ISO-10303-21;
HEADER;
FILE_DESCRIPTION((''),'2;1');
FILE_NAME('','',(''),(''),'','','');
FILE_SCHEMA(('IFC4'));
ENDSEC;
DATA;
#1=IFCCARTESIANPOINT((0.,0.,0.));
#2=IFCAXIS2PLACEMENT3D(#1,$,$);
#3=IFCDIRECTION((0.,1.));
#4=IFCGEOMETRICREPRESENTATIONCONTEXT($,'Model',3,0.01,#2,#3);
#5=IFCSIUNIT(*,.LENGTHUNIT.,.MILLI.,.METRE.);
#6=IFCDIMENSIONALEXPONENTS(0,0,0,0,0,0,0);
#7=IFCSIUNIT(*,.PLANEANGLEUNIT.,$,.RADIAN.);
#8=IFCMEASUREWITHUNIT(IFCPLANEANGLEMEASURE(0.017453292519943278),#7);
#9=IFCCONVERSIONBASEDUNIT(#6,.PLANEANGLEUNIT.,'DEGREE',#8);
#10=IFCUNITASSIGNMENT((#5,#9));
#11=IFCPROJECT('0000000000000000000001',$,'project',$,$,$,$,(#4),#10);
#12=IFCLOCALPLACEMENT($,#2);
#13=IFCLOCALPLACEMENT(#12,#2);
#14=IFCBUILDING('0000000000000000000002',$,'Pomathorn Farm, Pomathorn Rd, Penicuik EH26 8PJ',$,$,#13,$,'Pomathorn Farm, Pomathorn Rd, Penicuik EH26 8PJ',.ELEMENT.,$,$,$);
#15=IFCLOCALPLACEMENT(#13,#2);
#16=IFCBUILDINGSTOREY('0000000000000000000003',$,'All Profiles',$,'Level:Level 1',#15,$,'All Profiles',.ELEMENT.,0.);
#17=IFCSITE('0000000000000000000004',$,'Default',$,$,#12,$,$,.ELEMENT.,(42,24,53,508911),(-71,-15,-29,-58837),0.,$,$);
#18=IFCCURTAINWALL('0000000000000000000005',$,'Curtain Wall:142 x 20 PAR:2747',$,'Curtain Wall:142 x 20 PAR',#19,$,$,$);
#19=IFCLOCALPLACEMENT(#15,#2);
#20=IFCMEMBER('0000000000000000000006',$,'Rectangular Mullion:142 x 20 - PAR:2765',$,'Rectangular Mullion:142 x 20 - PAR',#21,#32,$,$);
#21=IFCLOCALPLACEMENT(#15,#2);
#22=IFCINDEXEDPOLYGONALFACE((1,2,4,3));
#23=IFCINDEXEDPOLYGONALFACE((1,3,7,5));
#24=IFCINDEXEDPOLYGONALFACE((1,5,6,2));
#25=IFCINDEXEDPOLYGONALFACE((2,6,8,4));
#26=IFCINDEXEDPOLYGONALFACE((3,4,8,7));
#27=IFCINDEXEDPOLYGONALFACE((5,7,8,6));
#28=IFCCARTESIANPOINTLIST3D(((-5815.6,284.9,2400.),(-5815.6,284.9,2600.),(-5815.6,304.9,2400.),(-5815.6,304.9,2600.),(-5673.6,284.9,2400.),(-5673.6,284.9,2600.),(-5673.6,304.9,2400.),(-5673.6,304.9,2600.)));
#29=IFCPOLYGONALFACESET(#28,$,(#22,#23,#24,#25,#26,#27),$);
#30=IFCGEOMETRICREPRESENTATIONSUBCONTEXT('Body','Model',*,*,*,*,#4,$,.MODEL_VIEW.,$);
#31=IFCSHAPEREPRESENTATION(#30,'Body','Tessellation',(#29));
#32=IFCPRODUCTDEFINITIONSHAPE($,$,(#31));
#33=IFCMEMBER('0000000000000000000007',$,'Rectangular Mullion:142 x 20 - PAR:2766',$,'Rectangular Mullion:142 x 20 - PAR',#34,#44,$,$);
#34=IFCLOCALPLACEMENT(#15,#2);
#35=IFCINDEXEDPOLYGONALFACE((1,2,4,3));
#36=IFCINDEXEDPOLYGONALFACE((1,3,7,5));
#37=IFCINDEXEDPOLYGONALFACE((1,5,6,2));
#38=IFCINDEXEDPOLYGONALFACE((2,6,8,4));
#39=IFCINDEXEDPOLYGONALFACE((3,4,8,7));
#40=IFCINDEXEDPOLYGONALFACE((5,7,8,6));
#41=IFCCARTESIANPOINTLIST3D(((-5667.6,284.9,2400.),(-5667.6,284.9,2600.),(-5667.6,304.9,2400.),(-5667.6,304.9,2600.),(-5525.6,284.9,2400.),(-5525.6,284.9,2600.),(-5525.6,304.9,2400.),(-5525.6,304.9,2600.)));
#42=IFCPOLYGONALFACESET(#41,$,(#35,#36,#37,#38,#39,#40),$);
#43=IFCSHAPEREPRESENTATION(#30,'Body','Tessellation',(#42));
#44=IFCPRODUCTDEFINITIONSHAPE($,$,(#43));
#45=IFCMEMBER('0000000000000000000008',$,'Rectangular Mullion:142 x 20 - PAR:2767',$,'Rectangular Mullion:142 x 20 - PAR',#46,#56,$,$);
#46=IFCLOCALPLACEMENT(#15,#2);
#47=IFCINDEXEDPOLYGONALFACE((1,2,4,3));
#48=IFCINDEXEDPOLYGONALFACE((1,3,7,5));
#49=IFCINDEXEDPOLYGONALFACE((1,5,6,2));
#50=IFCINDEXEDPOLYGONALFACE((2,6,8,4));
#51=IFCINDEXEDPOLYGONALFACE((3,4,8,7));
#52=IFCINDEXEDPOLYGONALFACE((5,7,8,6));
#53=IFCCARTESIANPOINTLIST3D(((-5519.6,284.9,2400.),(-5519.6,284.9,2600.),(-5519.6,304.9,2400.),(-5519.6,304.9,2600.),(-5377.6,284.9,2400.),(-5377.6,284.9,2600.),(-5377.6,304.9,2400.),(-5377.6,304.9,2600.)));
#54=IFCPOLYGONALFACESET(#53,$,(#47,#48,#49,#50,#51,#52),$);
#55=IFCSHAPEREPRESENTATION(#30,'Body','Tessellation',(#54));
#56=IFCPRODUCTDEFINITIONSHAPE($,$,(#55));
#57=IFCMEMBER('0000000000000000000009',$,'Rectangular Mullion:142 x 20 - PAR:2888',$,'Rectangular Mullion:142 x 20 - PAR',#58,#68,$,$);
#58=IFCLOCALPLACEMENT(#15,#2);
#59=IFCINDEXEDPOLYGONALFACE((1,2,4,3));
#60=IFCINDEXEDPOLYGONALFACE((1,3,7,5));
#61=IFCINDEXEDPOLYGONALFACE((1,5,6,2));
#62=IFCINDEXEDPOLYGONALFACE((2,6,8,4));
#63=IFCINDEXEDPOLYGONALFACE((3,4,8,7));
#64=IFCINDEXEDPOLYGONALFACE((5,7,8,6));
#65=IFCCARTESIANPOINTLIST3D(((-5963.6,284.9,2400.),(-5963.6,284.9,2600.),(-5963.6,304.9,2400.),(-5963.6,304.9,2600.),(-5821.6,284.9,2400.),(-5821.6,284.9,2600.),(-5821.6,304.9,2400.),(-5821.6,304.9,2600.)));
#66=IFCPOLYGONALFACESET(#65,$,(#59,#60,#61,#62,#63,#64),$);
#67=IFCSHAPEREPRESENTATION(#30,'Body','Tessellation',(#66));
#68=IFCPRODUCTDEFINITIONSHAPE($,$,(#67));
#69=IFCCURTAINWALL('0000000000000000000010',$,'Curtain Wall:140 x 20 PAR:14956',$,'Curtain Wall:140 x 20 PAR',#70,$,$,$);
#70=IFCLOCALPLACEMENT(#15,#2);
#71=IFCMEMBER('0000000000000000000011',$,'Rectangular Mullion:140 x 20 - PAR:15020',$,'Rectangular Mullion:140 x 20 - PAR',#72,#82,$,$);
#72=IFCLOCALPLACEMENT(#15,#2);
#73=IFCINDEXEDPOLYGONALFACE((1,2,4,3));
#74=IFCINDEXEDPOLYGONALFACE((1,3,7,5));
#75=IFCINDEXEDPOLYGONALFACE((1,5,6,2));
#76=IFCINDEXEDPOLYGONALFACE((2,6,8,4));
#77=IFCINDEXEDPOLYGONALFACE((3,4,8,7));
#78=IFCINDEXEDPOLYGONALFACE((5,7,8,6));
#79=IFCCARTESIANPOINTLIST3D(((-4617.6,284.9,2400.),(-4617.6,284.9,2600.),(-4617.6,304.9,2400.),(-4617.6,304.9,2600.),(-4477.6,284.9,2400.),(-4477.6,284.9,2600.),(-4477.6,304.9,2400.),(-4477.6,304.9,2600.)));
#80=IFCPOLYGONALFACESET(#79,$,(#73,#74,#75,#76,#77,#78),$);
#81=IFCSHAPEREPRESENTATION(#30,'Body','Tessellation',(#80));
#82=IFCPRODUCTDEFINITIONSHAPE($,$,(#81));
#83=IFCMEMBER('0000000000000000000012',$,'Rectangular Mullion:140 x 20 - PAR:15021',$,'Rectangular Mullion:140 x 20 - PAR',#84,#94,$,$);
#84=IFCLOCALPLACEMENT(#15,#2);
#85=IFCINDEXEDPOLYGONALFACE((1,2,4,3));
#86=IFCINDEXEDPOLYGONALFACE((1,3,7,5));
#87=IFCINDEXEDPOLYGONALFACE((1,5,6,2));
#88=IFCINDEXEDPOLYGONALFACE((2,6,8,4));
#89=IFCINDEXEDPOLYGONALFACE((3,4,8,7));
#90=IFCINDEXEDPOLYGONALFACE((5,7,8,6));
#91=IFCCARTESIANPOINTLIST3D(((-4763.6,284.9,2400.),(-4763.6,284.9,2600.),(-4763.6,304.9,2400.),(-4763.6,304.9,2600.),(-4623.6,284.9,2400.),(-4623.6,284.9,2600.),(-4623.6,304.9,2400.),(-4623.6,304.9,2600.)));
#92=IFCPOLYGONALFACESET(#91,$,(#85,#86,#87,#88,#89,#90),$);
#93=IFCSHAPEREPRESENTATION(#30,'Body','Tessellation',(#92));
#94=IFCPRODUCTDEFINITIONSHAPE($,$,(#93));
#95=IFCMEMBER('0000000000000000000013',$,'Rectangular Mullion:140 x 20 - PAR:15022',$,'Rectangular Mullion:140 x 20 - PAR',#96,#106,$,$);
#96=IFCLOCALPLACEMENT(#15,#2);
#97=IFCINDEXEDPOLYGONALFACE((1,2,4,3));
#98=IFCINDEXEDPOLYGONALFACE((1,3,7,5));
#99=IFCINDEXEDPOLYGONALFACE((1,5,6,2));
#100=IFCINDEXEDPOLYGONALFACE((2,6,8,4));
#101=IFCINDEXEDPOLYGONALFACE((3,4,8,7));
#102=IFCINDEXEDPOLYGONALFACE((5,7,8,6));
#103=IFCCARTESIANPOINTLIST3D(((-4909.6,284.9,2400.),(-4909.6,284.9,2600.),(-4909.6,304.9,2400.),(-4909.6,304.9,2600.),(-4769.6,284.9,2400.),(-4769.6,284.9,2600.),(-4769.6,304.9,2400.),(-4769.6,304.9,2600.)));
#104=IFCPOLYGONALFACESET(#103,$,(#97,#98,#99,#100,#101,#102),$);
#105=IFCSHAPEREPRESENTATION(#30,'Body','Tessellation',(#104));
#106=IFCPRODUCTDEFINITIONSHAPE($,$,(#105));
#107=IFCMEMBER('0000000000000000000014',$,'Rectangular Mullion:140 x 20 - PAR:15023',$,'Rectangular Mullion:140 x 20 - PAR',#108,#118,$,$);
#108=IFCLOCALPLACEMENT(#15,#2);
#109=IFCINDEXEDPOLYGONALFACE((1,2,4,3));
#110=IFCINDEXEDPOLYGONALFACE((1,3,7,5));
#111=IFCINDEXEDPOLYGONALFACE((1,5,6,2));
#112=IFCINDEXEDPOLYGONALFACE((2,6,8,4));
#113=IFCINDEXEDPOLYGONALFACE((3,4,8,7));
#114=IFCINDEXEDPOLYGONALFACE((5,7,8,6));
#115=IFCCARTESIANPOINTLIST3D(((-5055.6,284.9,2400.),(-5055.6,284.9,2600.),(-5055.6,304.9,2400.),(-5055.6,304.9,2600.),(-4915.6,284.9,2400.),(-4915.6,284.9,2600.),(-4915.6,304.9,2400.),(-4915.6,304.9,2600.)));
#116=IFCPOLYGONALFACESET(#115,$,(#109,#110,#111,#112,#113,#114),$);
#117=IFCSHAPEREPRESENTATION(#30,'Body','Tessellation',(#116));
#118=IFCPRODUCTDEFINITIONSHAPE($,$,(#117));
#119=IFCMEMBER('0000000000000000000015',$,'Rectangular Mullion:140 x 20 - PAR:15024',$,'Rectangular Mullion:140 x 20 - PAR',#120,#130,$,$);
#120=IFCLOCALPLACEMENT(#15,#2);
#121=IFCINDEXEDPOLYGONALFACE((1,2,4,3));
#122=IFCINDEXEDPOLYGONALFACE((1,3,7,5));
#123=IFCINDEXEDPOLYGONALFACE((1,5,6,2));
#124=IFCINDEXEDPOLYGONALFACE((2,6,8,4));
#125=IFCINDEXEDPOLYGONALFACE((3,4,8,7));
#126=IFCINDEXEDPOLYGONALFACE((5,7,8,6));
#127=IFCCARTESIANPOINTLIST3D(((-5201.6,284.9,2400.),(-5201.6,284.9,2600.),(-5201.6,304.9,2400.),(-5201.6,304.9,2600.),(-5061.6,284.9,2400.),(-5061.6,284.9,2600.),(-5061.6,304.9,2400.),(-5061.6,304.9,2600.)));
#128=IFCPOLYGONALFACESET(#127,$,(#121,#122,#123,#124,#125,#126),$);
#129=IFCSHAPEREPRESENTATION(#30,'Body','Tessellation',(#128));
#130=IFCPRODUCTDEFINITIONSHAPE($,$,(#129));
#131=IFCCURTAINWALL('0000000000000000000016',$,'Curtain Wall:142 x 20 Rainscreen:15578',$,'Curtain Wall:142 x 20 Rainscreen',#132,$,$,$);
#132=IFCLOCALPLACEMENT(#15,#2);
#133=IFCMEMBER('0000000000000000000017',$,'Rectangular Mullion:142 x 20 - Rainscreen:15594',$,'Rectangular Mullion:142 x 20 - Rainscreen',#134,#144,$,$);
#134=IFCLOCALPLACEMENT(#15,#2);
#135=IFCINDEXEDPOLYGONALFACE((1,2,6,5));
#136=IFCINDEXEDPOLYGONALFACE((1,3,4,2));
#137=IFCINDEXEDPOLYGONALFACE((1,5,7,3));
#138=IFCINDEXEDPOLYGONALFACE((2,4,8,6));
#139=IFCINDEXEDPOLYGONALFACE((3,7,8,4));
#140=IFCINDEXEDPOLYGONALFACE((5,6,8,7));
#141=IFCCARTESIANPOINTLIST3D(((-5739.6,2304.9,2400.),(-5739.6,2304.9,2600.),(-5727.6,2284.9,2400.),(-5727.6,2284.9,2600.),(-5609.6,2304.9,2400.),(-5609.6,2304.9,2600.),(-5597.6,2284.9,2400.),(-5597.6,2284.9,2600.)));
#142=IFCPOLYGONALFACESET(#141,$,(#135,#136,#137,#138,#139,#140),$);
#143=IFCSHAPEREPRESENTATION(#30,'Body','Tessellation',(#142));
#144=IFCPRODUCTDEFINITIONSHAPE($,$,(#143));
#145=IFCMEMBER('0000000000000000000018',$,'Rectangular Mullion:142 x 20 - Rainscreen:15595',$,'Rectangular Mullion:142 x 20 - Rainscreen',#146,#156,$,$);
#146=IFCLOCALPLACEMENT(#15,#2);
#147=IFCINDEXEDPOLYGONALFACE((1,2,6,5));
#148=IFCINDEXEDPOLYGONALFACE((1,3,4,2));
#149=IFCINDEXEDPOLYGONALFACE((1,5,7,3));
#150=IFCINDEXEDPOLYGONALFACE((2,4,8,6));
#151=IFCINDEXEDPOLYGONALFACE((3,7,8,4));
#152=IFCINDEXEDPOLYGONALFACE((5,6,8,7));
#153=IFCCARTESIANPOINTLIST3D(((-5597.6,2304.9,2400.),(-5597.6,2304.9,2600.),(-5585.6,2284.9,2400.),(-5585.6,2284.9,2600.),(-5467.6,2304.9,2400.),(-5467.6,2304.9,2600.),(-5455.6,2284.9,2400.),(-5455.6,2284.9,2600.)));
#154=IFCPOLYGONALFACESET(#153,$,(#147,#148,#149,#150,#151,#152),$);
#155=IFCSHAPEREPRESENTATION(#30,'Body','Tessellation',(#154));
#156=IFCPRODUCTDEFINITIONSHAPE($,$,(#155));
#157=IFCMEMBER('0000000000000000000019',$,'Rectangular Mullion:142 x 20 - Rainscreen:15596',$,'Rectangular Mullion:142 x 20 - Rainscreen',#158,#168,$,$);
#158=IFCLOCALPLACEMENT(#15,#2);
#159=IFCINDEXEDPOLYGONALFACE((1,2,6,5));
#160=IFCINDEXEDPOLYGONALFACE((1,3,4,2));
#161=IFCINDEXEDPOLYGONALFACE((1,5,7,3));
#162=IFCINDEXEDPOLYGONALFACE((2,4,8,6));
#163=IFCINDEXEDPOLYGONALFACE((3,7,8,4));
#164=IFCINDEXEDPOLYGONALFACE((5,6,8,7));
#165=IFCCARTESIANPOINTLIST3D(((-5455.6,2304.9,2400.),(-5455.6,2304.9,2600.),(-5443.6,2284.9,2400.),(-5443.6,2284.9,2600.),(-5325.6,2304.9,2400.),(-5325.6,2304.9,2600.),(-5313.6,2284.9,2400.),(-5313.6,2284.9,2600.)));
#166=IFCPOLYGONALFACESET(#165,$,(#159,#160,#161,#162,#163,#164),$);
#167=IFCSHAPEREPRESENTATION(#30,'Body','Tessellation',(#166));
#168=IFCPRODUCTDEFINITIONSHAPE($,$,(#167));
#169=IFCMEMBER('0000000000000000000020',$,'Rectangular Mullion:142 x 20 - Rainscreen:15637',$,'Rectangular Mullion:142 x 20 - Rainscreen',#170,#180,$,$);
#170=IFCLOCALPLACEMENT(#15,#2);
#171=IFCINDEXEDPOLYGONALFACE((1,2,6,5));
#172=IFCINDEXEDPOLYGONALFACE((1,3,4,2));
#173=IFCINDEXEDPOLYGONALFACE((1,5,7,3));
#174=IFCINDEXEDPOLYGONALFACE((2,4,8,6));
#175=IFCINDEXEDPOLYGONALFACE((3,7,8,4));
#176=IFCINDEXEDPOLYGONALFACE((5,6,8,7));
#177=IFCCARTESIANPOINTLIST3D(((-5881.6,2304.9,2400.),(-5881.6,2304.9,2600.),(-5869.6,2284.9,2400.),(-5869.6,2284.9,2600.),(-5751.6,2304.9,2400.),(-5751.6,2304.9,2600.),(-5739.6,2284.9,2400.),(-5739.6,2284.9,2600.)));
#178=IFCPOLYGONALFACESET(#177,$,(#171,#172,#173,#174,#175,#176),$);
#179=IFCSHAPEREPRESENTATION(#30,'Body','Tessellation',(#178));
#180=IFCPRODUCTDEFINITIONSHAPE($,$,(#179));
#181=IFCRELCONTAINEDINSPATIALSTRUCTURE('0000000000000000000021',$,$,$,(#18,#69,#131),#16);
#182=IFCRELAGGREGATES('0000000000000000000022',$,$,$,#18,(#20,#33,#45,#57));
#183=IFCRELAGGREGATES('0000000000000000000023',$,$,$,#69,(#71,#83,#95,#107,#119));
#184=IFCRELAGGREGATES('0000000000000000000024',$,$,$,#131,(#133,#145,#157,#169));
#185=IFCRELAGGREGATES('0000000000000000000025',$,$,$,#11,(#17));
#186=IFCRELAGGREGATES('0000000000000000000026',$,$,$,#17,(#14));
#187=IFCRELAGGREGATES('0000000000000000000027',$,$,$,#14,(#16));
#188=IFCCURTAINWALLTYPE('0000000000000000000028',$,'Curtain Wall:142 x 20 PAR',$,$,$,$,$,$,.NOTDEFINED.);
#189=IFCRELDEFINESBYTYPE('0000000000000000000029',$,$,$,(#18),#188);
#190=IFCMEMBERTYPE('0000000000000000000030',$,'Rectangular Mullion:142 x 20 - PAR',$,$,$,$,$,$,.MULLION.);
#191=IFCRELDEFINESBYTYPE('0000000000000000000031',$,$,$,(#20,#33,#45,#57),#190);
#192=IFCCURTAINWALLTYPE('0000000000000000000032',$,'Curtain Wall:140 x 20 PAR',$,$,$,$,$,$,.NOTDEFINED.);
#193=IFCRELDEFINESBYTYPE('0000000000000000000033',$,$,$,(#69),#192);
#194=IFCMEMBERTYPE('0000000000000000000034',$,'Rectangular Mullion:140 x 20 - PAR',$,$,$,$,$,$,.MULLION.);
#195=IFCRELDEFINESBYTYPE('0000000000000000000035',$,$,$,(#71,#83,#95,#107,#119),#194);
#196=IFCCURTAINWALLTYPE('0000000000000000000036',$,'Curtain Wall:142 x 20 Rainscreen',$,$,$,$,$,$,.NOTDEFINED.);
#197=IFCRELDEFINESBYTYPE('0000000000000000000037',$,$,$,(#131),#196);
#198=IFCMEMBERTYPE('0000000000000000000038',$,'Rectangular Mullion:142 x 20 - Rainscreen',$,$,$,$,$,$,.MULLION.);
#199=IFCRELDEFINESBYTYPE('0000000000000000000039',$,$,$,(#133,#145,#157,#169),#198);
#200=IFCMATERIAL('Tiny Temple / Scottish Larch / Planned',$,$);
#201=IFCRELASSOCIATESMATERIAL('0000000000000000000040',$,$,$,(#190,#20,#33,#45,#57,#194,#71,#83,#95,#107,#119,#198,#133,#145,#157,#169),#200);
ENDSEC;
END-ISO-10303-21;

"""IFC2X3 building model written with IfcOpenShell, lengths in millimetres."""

from ifc_helpers import new_model, entity, si_unit, converted_unit, direction, frame, frame_2d, origin, place, context, subcontext, project, spatial, polyline, rectangle, outline, extrude, source, transform, mapped, material, type_object, type_shapes, element, aggregate, save


model = new_model("IFC2X3")

# Units and contexts
model_context = context("Model", 3, precision=0.01, world=origin(), true_north=direction((0.0, 1.0)))
body_context = subcontext(model_context, "Body", "Model", "MODEL_VIEW")
ifc_project = project(units=[si_unit("LENGTHUNIT", "METRE", prefix="MILLI"), converted_unit("PLANEANGLEUNIT", "DEGREE", entity("IfcPlaneAngleMeasure", 0.017453292519943278), si_unit("PLANEANGLEUNIT", "RADIAN"), dimensions=[0, 0, 0, 0, 0, 0, 0])], contexts=[model_context])

# Site, building, storey
site_placement = place(None, origin())
site = spatial("IfcSite", under=ifc_project, at=site_placement, Name="Default", CompositionType="ELEMENT", RefLatitude=(42, 24, 53, 508911), RefLongitude=(-71, -15, -29, -58837), RefElevation=0.0)
building_placement = place(site_placement, origin())
building = spatial("IfcBuilding", under=site, at=building_placement, Name="Pomathorn Farm, Pomathorn Rd, Penicuik EH26 8PJ", LongName="Pomathorn Farm, Pomathorn Rd, Penicuik EH26 8PJ", CompositionType="ELEMENT")
storey_placement = place(building_placement, origin())
storey = spatial("IfcBuildingStorey", under=building, at=storey_placement, Name="All Profiles", ObjectType="Level:Level 1", LongName="All Profiles", CompositionType="ELEMENT", Elevation=0.0)

# Curtain walls, members
curtain_wall_type_1 = type_object("IfcCurtainWallType", Name="Curtain Wall:142 x 20 PAR", PredefinedType="NOTDEFINED")
curtain_wall_1_placement = place(storey_placement, origin())
curtain_wall_1 = element("IfcCurtainWall", 1, at=curtain_wall_1_placement, inside=storey, type_object=curtain_wall_type_1, Name="Curtain Wall:142 x 20 PAR:2747", ObjectType="Curtain Wall:142 x 20 PAR")
ifc_material = material(Name="Tiny Temple / Scottish Larch / Planned")
member_type_1 = type_object("IfcMemberType", Name="Rectangular Mullion:142 x 20 - PAR", PredefinedType="MULLION", material=ifc_material)
shared_shape_1 = source(origin(), body_context, "Body", "SweptSolid", [
    extrude(rectangle(XDim=20.0, YDim=142.0, at=frame_2d((0.0, 0.0), x_axis=(1.0, 0.0))), frame((-71.0, -10.0, -200.0), z_axis=(0.0, 0.0, 1.0), x_axis=(0.0, 1.0, 0.0)), (0.0, 0.0, 1.0), 200.0),
])
type_shapes(member_type_1, [shared_shape_1])
member_1_placement = place(curtain_wall_1_placement, frame((-5673.6, 284.9, 2400.0), z_axis=(0.0, 0.0, -1.0), x_axis=(1.0, 0.0, 0.0)))
member_1 = element("IfcMember", 2, at=member_1_placement, type_object=member_type_1, material=ifc_material, Name="Rectangular Mullion:142 x 20 - PAR:2765", ObjectType="Rectangular Mullion:142 x 20 - PAR", context=body_context, shape_type="MappedRepresentation", body=[
    mapped(shared_shape_1, transform((0.0, 0.0, 0.0), scale=1.0)),
])
member_2_placement = place(curtain_wall_1_placement, frame((-5525.6, 284.9, 2400.0), z_axis=(0.0, 0.0, -1.0), x_axis=(1.0, 0.0, 0.0)))
member_2 = element("IfcMember", 3, at=member_2_placement, type_object=member_type_1, material=ifc_material, Name="Rectangular Mullion:142 x 20 - PAR:2766", ObjectType="Rectangular Mullion:142 x 20 - PAR", context=body_context, shape_type="MappedRepresentation", body=[
    mapped(shared_shape_1, transform((0.0, 0.0, 0.0), scale=1.0)),
])
member_3_placement = place(curtain_wall_1_placement, frame((-5377.6, 284.9, 2400.0), z_axis=(0.0, 0.0, -1.0), x_axis=(1.0, 0.0, 0.0)))
member_3 = element("IfcMember", 4, at=member_3_placement, type_object=member_type_1, material=ifc_material, Name="Rectangular Mullion:142 x 20 - PAR:2767", ObjectType="Rectangular Mullion:142 x 20 - PAR", context=body_context, shape_type="MappedRepresentation", body=[
    mapped(shared_shape_1, transform((0.0, 0.0, 0.0), scale=1.0)),
])
member_4_placement = place(curtain_wall_1_placement, frame((-5821.6, 284.9, 2400.0), z_axis=(0.0, 0.0, -1.0), x_axis=(1.0, 0.0, 0.0)))
member_4 = element("IfcMember", 5, at=member_4_placement, type_object=member_type_1, material=ifc_material, Name="Rectangular Mullion:142 x 20 - PAR:2888", ObjectType="Rectangular Mullion:142 x 20 - PAR", context=body_context, shape_type="MappedRepresentation", body=[
    mapped(shared_shape_1, transform((0.0, 0.0, 0.0), scale=1.0)),
])
aggregate(curtain_wall_1, [member_1, member_2, member_3, member_4])
curtain_wall_type_2 = type_object("IfcCurtainWallType", Name="Curtain Wall:140 x 20 PAR", PredefinedType="NOTDEFINED")
curtain_wall_2_placement = place(storey_placement, origin())
curtain_wall_2 = element("IfcCurtainWall", 6, at=curtain_wall_2_placement, inside=storey, type_object=curtain_wall_type_2, Name="Curtain Wall:140 x 20 PAR:14956", ObjectType="Curtain Wall:140 x 20 PAR")
member_type_2 = type_object("IfcMemberType", Name="Rectangular Mullion:140 x 20 - PAR", PredefinedType="MULLION", material=ifc_material)
shared_shape_2 = source(origin(), body_context, "Body", "SweptSolid", [
    extrude(rectangle(XDim=20.0, YDim=140.0, at=frame_2d((0.0, 0.0), x_axis=(1.0, 0.0))), frame((-70.0, -10.0, -200.0), z_axis=(0.0, 0.0, 1.0), x_axis=(0.0, 1.0, 0.0)), (0.0, 0.0, 1.0), 200.0),
])
type_shapes(member_type_2, [shared_shape_2])
member_5_placement = place(curtain_wall_2_placement, frame((-4477.6, 284.9, 2400.0), z_axis=(0.0, 0.0, -1.0), x_axis=(1.0, 0.0, 0.0)))
member_5 = element("IfcMember", 7, at=member_5_placement, type_object=member_type_2, material=ifc_material, Name="Rectangular Mullion:140 x 20 - PAR:15020", ObjectType="Rectangular Mullion:140 x 20 - PAR", context=body_context, shape_type="MappedRepresentation", body=[
    mapped(shared_shape_2, transform((0.0, 0.0, 0.0), scale=1.0)),
])
member_6_placement = place(curtain_wall_2_placement, frame((-4623.6, 284.9, 2400.0), z_axis=(0.0, 0.0, -1.0), x_axis=(1.0, 0.0, 0.0)))
member_6 = element("IfcMember", 8, at=member_6_placement, type_object=member_type_2, material=ifc_material, Name="Rectangular Mullion:140 x 20 - PAR:15021", ObjectType="Rectangular Mullion:140 x 20 - PAR", context=body_context, shape_type="MappedRepresentation", body=[
    mapped(shared_shape_2, transform((0.0, 0.0, 0.0), scale=1.0)),
])
member_7_placement = place(curtain_wall_2_placement, frame((-4769.6, 284.9, 2400.0), z_axis=(0.0, 0.0, -1.0), x_axis=(1.0, 0.0, 0.0)))
member_7 = element("IfcMember", 9, at=member_7_placement, type_object=member_type_2, material=ifc_material, Name="Rectangular Mullion:140 x 20 - PAR:15022", ObjectType="Rectangular Mullion:140 x 20 - PAR", context=body_context, shape_type="MappedRepresentation", body=[
    mapped(shared_shape_2, transform((0.0, 0.0, 0.0), scale=1.0)),
])
member_8_placement = place(curtain_wall_2_placement, frame((-4915.6, 284.9, 2400.0), z_axis=(0.0, 0.0, -1.0), x_axis=(1.0, 0.0, 0.0)))
member_8 = element("IfcMember", 10, at=member_8_placement, type_object=member_type_2, material=ifc_material, Name="Rectangular Mullion:140 x 20 - PAR:15023", ObjectType="Rectangular Mullion:140 x 20 - PAR", context=body_context, shape_type="MappedRepresentation", body=[
    mapped(shared_shape_2, transform((0.0, 0.0, 0.0), scale=1.0)),
])
member_9_placement = place(curtain_wall_2_placement, frame((-5061.6, 284.9, 2400.0), z_axis=(0.0, 0.0, -1.0), x_axis=(1.0, 0.0, 0.0)))
member_9 = element("IfcMember", 11, at=member_9_placement, type_object=member_type_2, material=ifc_material, Name="Rectangular Mullion:140 x 20 - PAR:15024", ObjectType="Rectangular Mullion:140 x 20 - PAR", context=body_context, shape_type="MappedRepresentation", body=[
    mapped(shared_shape_2, transform((0.0, 0.0, 0.0), scale=1.0)),
])
aggregate(curtain_wall_2, [member_5, member_6, member_7, member_8, member_9])
curtain_wall_type_3 = type_object("IfcCurtainWallType", Name="Curtain Wall:142 x 20 Rainscreen", PredefinedType="NOTDEFINED")
curtain_wall_3_placement = place(storey_placement, origin())
curtain_wall_3 = element("IfcCurtainWall", 12, at=curtain_wall_3_placement, inside=storey, type_object=curtain_wall_type_3, Name="Curtain Wall:142 x 20 Rainscreen:15578", ObjectType="Curtain Wall:142 x 20 Rainscreen")
member_type_3 = type_object("IfcMemberType", Name="Rectangular Mullion:142 x 20 - Rainscreen", PredefinedType="MULLION", material=ifc_material)
shared_shape_3 = source(origin(), body_context, "Body", "SweptSolid", [
    extrude(outline(polyline([(21.8, -55.7), (45.1, -55.7), (-21.8, 55.7), (-45.1, 55.7), (21.8, -55.7)])), frame((-71.0, -10.0, -200.0), z_axis=(0.0, 0.0, 1.0), x_axis=(0.514496, 0.857493, 0.0)), (0.0, 0.0, 1.0), 200.0),
])
type_shapes(member_type_3, [shared_shape_3])
member_10_placement = place(curtain_wall_3_placement, frame((-5597.6, 2284.9, 2400.0), z_axis=(0.0, 0.0, -1.0), x_axis=(1.0, 0.0, 0.0)))
member_10 = element("IfcMember", 13, at=member_10_placement, type_object=member_type_3, material=ifc_material, Name="Rectangular Mullion:142 x 20 - Rainscreen:15594", ObjectType="Rectangular Mullion:142 x 20 - Rainscreen", context=body_context, shape_type="MappedRepresentation", body=[
    mapped(shared_shape_3, transform((0.0, 0.0, 0.0), scale=1.0)),
])
member_11_placement = place(curtain_wall_3_placement, frame((-5455.6, 2284.9, 2400.0), z_axis=(0.0, 0.0, -1.0), x_axis=(1.0, 0.0, 0.0)))
member_11 = element("IfcMember", 14, at=member_11_placement, type_object=member_type_3, material=ifc_material, Name="Rectangular Mullion:142 x 20 - Rainscreen:15595", ObjectType="Rectangular Mullion:142 x 20 - Rainscreen", context=body_context, shape_type="MappedRepresentation", body=[
    mapped(shared_shape_3, transform((0.0, 0.0, 0.0), scale=1.0)),
])
member_12_placement = place(curtain_wall_3_placement, frame((-5313.6, 2284.9, 2400.0), z_axis=(0.0, 0.0, -1.0), x_axis=(1.0, 0.0, 0.0)))
member_12 = element("IfcMember", 15, at=member_12_placement, type_object=member_type_3, material=ifc_material, Name="Rectangular Mullion:142 x 20 - Rainscreen:15596", ObjectType="Rectangular Mullion:142 x 20 - Rainscreen", context=body_context, shape_type="MappedRepresentation", body=[
    mapped(shared_shape_3, transform((0.0, 0.0, 0.0), scale=1.0)),
])
member_13_placement = place(curtain_wall_3_placement, frame((-5739.6, 2284.9, 2400.0), z_axis=(0.0, 0.0, -1.0), x_axis=(1.0, 0.0, 0.0)))
member_13 = element("IfcMember", 16, at=member_13_placement, type_object=member_type_3, material=ifc_material, Name="Rectangular Mullion:142 x 20 - Rainscreen:15637", ObjectType="Rectangular Mullion:142 x 20 - Rainscreen", context=body_context, shape_type="MappedRepresentation", body=[
    mapped(shared_shape_3, transform((0.0, 0.0, 0.0), scale=1.0)),
])
aggregate(curtain_wall_3, [member_10, member_11, member_12, member_13])

save(model, "model.ifc")
